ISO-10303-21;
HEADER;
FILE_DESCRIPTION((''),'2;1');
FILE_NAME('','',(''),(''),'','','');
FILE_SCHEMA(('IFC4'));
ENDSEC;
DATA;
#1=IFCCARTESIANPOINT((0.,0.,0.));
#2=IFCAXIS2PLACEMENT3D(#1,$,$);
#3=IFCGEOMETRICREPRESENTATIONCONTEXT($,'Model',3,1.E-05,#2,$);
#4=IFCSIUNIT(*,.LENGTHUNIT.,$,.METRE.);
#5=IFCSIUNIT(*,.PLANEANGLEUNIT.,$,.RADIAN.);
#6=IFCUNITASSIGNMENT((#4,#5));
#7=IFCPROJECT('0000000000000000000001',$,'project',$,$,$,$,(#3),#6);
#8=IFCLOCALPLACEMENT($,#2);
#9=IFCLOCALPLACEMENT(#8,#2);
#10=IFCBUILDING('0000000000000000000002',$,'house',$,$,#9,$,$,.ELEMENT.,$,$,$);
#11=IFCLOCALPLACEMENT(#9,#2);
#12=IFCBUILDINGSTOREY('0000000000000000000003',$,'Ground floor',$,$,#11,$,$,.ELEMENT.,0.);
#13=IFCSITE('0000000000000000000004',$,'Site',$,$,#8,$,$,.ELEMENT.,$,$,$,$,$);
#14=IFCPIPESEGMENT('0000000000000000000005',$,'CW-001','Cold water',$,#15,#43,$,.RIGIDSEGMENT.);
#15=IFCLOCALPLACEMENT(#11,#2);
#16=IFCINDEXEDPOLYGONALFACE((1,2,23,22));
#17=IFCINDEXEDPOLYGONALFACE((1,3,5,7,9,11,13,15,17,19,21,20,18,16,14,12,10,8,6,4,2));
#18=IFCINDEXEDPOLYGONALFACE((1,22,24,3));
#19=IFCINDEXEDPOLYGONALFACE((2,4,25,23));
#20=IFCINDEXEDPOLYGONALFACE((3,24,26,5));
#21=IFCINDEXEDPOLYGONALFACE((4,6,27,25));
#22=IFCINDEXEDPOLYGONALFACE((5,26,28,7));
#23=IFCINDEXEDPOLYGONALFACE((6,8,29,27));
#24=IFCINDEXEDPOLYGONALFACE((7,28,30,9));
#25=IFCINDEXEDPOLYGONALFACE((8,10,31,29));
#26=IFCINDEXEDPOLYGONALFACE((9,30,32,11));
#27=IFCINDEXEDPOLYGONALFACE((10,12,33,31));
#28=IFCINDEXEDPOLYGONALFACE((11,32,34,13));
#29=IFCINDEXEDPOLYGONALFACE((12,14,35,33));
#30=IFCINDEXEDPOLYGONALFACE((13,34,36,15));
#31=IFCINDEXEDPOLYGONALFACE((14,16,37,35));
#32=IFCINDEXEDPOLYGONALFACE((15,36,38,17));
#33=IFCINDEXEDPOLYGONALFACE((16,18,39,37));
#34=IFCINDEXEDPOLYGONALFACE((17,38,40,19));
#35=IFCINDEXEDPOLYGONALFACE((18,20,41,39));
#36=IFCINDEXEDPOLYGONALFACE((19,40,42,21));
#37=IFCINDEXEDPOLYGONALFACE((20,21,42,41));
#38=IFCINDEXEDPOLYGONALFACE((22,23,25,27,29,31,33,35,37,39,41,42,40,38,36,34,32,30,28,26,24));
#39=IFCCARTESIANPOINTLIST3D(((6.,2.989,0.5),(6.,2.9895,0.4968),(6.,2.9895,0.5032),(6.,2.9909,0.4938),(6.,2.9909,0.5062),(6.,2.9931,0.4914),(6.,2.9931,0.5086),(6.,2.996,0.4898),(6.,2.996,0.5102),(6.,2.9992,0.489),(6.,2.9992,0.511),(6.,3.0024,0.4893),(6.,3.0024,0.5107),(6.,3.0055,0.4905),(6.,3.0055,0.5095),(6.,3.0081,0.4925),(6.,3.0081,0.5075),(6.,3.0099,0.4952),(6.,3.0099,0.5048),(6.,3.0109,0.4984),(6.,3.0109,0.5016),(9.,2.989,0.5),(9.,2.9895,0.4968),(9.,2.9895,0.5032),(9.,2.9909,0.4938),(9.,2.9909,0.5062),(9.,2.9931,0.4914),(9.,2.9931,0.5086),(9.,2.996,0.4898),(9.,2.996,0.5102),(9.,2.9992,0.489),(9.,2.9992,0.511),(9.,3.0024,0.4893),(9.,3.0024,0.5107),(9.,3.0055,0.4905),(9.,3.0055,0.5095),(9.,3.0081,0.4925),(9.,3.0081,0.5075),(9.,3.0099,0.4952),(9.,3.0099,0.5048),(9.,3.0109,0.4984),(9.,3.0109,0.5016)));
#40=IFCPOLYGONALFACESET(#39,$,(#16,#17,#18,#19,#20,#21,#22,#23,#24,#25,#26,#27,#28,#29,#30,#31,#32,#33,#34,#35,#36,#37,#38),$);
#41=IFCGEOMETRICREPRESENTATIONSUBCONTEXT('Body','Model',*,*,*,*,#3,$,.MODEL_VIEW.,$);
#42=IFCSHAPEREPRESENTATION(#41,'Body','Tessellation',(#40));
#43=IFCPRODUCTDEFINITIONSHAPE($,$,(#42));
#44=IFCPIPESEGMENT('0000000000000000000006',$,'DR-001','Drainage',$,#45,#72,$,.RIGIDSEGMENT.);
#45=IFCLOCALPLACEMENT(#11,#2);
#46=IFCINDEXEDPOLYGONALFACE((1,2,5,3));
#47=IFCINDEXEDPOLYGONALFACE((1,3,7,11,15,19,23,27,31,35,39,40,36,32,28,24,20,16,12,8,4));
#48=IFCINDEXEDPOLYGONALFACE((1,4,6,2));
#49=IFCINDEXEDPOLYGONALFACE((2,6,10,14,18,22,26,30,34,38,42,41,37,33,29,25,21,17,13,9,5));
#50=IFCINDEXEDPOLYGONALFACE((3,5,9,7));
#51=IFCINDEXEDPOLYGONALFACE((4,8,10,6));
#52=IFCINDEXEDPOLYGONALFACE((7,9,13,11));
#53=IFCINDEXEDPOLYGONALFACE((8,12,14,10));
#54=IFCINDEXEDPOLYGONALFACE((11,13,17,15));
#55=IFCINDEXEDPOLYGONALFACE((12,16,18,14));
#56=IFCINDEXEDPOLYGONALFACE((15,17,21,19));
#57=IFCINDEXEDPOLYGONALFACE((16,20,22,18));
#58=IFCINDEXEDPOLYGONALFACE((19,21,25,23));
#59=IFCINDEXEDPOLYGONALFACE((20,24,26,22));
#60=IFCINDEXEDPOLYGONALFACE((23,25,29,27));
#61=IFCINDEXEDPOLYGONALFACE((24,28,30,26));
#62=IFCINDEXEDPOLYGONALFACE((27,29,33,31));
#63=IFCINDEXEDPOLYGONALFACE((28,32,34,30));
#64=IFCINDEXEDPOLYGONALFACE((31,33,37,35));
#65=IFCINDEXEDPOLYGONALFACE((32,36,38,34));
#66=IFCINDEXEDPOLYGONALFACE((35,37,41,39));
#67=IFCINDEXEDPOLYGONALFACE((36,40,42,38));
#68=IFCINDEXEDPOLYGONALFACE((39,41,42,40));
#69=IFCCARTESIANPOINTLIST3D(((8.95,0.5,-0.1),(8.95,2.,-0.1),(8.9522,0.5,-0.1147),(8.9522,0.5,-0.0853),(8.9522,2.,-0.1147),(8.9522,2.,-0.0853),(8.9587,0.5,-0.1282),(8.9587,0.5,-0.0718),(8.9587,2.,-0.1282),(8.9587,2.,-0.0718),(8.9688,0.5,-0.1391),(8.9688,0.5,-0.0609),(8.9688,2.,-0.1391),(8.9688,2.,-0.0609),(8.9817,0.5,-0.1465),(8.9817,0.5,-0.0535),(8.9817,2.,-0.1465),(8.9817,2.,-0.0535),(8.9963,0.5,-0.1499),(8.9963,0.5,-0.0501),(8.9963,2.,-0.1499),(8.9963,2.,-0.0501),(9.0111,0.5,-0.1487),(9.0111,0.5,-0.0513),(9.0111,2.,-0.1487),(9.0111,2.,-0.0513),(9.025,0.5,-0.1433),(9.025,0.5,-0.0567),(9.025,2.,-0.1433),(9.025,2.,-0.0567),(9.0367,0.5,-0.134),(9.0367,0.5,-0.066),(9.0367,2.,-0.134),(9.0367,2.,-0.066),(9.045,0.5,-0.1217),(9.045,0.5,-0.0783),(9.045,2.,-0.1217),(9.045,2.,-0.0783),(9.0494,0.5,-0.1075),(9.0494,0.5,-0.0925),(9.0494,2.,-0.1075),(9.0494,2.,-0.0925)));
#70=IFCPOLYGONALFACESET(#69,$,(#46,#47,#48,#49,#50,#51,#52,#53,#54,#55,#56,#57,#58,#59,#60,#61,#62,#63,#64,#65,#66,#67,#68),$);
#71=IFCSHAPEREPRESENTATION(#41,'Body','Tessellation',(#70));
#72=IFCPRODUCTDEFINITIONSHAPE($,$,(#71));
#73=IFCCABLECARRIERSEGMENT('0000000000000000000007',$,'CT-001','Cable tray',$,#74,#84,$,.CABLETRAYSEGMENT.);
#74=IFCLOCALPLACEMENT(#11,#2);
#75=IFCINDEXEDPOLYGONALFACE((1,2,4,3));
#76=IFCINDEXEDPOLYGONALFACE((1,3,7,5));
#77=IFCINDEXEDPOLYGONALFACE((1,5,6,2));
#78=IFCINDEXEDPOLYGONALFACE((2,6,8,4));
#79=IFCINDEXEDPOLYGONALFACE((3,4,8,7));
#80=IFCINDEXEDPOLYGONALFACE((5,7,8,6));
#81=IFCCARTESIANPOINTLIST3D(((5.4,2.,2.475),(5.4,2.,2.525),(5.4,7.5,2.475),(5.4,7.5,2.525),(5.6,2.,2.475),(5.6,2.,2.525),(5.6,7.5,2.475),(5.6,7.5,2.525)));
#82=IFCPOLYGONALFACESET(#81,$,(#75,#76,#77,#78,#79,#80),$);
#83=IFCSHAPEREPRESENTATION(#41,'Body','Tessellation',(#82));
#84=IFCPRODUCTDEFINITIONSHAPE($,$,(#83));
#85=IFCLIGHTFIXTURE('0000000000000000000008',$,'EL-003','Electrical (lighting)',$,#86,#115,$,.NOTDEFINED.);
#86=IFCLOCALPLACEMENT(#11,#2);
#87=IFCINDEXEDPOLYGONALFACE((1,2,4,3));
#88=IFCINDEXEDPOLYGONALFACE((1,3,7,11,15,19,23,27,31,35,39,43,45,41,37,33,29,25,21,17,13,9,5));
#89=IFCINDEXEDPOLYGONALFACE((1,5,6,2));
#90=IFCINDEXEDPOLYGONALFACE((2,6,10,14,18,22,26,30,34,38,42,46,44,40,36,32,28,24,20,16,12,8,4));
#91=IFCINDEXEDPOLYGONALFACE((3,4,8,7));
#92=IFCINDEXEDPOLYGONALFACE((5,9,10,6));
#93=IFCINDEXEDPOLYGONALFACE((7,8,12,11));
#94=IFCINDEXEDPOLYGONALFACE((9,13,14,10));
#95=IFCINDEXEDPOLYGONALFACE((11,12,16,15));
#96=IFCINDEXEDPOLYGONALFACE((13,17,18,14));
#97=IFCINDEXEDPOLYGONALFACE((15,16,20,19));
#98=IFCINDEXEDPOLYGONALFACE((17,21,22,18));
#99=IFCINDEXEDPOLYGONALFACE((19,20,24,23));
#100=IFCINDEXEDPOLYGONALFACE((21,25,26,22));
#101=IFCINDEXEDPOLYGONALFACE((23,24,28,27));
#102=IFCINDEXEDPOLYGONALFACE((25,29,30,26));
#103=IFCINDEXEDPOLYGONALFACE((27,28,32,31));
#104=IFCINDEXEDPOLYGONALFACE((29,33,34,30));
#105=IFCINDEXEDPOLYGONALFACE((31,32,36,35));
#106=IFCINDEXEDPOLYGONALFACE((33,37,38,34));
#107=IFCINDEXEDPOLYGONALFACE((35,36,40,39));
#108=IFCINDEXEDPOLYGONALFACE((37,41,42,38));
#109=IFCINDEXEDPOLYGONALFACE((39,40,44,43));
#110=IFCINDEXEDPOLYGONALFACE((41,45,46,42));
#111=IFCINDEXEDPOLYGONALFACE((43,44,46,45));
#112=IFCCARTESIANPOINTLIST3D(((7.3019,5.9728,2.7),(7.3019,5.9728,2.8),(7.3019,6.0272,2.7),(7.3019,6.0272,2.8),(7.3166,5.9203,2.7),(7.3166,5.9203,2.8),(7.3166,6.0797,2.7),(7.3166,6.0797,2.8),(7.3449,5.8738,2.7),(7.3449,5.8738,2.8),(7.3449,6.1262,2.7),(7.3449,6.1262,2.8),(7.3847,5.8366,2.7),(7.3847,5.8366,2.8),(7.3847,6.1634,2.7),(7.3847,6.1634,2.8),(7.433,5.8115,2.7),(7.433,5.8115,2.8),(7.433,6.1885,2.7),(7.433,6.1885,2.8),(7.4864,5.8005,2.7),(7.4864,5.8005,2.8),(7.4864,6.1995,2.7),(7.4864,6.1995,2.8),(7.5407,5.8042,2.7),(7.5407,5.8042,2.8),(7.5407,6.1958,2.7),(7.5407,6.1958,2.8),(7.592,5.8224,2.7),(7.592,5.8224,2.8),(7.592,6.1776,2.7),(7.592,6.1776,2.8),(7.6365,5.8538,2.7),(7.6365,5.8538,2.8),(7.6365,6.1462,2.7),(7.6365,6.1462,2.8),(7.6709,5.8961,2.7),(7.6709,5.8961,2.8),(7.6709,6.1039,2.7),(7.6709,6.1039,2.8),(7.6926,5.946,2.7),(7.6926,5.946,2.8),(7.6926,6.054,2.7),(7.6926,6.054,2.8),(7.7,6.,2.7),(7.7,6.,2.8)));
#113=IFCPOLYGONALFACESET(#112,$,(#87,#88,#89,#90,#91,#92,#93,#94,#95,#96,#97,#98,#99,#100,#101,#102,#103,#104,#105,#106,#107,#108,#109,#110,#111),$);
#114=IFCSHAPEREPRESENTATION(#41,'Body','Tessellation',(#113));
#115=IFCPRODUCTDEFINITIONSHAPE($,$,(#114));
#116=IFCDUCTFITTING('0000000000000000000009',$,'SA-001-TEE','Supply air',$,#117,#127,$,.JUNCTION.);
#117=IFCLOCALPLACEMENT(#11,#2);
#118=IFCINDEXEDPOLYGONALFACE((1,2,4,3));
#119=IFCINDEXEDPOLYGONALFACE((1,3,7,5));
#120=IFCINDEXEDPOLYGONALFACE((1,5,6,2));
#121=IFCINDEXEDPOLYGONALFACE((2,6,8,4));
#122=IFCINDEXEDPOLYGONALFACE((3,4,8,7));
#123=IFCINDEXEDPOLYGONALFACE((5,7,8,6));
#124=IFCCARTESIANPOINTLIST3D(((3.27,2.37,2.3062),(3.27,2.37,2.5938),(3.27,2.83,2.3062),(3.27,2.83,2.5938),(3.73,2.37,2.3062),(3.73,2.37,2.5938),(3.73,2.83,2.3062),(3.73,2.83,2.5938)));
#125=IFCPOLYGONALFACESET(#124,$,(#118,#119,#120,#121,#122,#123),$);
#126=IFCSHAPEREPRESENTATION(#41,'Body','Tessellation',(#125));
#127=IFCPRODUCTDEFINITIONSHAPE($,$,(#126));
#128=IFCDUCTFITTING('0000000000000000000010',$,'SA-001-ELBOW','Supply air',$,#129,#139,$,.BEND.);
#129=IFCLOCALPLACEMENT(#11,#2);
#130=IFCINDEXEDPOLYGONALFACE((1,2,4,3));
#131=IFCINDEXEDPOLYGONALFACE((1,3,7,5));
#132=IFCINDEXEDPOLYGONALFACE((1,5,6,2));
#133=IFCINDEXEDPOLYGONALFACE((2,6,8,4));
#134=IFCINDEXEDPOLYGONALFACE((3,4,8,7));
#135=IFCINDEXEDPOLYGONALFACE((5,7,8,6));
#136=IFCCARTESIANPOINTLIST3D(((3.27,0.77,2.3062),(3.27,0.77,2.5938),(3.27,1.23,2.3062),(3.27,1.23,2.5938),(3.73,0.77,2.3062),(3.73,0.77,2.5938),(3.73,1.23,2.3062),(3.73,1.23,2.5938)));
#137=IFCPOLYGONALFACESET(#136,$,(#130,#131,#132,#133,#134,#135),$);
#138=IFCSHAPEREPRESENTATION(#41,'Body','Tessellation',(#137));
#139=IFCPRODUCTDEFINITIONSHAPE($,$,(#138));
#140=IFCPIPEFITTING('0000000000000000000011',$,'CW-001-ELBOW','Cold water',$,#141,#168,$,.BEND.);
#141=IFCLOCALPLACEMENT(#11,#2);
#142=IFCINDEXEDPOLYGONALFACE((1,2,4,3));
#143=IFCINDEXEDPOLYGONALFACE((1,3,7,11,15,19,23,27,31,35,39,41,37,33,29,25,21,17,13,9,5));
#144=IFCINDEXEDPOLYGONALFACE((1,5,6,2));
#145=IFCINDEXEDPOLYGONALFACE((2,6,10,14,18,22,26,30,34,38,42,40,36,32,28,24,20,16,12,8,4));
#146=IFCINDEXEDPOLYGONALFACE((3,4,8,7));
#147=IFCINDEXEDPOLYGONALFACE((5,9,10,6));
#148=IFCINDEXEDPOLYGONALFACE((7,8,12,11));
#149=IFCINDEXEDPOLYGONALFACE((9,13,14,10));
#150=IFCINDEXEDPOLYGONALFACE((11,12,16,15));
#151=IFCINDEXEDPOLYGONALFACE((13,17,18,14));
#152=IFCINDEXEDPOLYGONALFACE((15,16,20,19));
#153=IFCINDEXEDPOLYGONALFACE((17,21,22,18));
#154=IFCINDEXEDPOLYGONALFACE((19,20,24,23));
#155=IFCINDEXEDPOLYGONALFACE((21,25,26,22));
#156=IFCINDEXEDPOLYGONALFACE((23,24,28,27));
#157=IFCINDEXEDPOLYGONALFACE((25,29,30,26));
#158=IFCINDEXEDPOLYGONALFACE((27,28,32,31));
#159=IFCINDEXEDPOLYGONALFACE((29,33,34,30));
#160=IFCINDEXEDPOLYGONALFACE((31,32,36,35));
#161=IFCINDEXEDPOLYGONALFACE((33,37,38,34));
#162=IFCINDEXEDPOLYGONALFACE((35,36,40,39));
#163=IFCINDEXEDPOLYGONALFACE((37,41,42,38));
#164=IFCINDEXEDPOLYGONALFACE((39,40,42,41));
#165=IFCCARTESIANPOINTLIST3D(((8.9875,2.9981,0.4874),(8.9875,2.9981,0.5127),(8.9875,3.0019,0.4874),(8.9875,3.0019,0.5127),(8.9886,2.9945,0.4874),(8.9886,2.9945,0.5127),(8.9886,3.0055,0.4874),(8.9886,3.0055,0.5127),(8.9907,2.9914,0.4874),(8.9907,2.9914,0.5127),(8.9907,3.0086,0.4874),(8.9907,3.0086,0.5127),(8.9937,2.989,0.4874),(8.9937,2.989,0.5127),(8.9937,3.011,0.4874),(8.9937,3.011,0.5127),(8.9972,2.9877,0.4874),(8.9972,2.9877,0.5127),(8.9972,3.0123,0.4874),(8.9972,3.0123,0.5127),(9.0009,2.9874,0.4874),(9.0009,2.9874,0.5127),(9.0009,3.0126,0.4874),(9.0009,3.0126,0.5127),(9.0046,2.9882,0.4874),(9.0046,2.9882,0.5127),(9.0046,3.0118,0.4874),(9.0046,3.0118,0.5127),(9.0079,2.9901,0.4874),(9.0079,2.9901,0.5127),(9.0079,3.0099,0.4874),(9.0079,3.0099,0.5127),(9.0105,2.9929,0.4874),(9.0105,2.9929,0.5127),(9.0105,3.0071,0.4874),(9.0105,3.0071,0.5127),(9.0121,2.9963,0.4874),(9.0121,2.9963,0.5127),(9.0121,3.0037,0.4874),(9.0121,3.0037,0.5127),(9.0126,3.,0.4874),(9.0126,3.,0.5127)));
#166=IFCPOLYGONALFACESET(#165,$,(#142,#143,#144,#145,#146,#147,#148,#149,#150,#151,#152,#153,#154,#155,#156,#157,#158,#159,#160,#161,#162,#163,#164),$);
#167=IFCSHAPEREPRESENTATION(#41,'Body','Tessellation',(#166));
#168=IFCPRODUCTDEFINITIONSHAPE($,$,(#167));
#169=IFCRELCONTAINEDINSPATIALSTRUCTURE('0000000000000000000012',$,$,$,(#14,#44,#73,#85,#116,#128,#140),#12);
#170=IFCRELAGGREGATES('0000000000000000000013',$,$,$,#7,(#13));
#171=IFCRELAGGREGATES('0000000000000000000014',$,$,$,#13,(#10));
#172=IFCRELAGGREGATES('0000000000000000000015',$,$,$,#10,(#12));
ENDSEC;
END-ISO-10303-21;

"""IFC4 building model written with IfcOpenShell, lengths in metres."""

from ifc_helpers import new_model, si_unit, frame, origin, origin_2d, place, context, subcontext, project, spatial, rectangle, circle, extrude, element, save


model = new_model("IFC4")

# Units and contexts
model_context = context("Model", 3, precision=1e-05, world=origin())
body_context = subcontext(model_context, "Body", "Model", "MODEL_VIEW")
ifc_project = project(units=[si_unit("LENGTHUNIT", "METRE"), si_unit("PLANEANGLEUNIT", "RADIAN")], contexts=[model_context])

# Site, building, storey
site_placement = place(None, origin())
site = spatial("IfcSite", under=ifc_project, at=site_placement, Name="Site", CompositionType="ELEMENT")
building_placement = place(site_placement, origin())
building = spatial("IfcBuilding", under=site, at=building_placement, Name="house", CompositionType="ELEMENT")
storey_placement = place(building_placement, origin())
storey = spatial("IfcBuildingStorey", under=building, at=storey_placement, Name="Ground floor", CompositionType="ELEMENT", Elevation=0.0)

# Pipe segments
pipe_segment_1_placement = place(storey_placement, frame((9.0, 3.0, 0.5), z_axis=(-1.0, 0.0, 0.0), x_axis=(0.0, -1.0, 0.0)))
element("IfcPipeSegment", 1, at=pipe_segment_1_placement, inside=storey, Name="CW-001", Description="Cold water", PredefinedType="RIGIDSEGMENT", context=body_context, shape_type="SweptSolid", body=[
    extrude(circle(Radius=0.011, at=origin_2d()), origin(), (0.0, 0.0, 1.0), 3.0),
])
pipe_segment_2_placement = place(storey_placement, frame((9.0, 0.5, -0.1), z_axis=(0.0, 1.0, 0.0), x_axis=(-1.0, 0.0, 0.0)))
element("IfcPipeSegment", 2, at=pipe_segment_2_placement, inside=storey, Name="DR-001", Description="Drainage", PredefinedType="RIGIDSEGMENT", context=body_context, shape_type="SweptSolid", body=[
    extrude(circle(Radius=0.05, at=origin_2d()), origin(), (0.0, 0.0, 1.0), 1.5),
])

# Cable carrier segment
cable_carrier_segment_placement = place(storey_placement, frame((5.5, 2.0, 2.5), z_axis=(0.0, 1.0, 0.0), x_axis=(-1.0, 0.0, 0.0)))
element("IfcCableCarrierSegment", 3, at=cable_carrier_segment_placement, inside=storey, Name="CT-001", Description="Cable tray", PredefinedType="CABLETRAYSEGMENT", context=body_context, shape_type="SweptSolid", body=[
    extrude(rectangle(XDim=0.2, YDim=0.05, at=origin_2d()), origin(), (0.0, 0.0, 1.0), 5.5),
])

# Light fixture
light_fixture_placement = place(storey_placement, frame((7.5, 6.0, 2.7), z_axis=(0.0, 0.0, 1.0), x_axis=(1.0, 0.0, 0.0)))
element("IfcLightFixture", 4, at=light_fixture_placement, inside=storey, Name="EL-003", Description="Electrical (lighting)", PredefinedType="NOTDEFINED", context=body_context, shape_type="SweptSolid", body=[
    extrude(circle(Radius=0.2, at=origin_2d()), origin(), (0.0, 0.0, 1.0), 0.1),
])

# Duct fittings
duct_fitting_1_placement = place(storey_placement, frame((3.5, 2.6, 2.3062), z_axis=(0.0, 0.0, 1.0), x_axis=(1.0, 0.0, 0.0)))
element("IfcDuctFitting", 5, at=duct_fitting_1_placement, inside=storey, Name="SA-001-TEE", Description="Supply air", PredefinedType="JUNCTION", context=body_context, shape_type="SweptSolid", body=[
    extrude(rectangle(XDim=0.46, YDim=0.46, at=origin_2d()), origin(), (0.0, 0.0, 1.0), 0.2875),
])
duct_fitting_2_placement = place(storey_placement, frame((3.5, 1.0, 2.3062), z_axis=(0.0, 0.0, 1.0), x_axis=(1.0, 0.0, 0.0)))
element("IfcDuctFitting", 6, at=duct_fitting_2_placement, inside=storey, Name="SA-001-ELBOW", Description="Supply air", PredefinedType="BEND", context=body_context, shape_type="SweptSolid", body=[
    extrude(rectangle(XDim=0.46, YDim=0.46, at=origin_2d()), origin(), (0.0, 0.0, 1.0), 0.2875),
])

# Pipe fitting
pipe_fitting_placement = place(storey_placement, frame((9.0, 3.0, 0.4874), z_axis=(0.0, 0.0, 1.0), x_axis=(1.0, 0.0, 0.0)))
element("IfcPipeFitting", 7, at=pipe_fitting_placement, inside=storey, Name="CW-001-ELBOW", Description="Cold water", PredefinedType="BEND", context=body_context, shape_type="SweptSolid", body=[
    extrude(circle(Radius=0.0126, at=origin_2d()), origin(), (0.0, 0.0, 1.0), 0.0253),
])

save(model, "model.ifc")
